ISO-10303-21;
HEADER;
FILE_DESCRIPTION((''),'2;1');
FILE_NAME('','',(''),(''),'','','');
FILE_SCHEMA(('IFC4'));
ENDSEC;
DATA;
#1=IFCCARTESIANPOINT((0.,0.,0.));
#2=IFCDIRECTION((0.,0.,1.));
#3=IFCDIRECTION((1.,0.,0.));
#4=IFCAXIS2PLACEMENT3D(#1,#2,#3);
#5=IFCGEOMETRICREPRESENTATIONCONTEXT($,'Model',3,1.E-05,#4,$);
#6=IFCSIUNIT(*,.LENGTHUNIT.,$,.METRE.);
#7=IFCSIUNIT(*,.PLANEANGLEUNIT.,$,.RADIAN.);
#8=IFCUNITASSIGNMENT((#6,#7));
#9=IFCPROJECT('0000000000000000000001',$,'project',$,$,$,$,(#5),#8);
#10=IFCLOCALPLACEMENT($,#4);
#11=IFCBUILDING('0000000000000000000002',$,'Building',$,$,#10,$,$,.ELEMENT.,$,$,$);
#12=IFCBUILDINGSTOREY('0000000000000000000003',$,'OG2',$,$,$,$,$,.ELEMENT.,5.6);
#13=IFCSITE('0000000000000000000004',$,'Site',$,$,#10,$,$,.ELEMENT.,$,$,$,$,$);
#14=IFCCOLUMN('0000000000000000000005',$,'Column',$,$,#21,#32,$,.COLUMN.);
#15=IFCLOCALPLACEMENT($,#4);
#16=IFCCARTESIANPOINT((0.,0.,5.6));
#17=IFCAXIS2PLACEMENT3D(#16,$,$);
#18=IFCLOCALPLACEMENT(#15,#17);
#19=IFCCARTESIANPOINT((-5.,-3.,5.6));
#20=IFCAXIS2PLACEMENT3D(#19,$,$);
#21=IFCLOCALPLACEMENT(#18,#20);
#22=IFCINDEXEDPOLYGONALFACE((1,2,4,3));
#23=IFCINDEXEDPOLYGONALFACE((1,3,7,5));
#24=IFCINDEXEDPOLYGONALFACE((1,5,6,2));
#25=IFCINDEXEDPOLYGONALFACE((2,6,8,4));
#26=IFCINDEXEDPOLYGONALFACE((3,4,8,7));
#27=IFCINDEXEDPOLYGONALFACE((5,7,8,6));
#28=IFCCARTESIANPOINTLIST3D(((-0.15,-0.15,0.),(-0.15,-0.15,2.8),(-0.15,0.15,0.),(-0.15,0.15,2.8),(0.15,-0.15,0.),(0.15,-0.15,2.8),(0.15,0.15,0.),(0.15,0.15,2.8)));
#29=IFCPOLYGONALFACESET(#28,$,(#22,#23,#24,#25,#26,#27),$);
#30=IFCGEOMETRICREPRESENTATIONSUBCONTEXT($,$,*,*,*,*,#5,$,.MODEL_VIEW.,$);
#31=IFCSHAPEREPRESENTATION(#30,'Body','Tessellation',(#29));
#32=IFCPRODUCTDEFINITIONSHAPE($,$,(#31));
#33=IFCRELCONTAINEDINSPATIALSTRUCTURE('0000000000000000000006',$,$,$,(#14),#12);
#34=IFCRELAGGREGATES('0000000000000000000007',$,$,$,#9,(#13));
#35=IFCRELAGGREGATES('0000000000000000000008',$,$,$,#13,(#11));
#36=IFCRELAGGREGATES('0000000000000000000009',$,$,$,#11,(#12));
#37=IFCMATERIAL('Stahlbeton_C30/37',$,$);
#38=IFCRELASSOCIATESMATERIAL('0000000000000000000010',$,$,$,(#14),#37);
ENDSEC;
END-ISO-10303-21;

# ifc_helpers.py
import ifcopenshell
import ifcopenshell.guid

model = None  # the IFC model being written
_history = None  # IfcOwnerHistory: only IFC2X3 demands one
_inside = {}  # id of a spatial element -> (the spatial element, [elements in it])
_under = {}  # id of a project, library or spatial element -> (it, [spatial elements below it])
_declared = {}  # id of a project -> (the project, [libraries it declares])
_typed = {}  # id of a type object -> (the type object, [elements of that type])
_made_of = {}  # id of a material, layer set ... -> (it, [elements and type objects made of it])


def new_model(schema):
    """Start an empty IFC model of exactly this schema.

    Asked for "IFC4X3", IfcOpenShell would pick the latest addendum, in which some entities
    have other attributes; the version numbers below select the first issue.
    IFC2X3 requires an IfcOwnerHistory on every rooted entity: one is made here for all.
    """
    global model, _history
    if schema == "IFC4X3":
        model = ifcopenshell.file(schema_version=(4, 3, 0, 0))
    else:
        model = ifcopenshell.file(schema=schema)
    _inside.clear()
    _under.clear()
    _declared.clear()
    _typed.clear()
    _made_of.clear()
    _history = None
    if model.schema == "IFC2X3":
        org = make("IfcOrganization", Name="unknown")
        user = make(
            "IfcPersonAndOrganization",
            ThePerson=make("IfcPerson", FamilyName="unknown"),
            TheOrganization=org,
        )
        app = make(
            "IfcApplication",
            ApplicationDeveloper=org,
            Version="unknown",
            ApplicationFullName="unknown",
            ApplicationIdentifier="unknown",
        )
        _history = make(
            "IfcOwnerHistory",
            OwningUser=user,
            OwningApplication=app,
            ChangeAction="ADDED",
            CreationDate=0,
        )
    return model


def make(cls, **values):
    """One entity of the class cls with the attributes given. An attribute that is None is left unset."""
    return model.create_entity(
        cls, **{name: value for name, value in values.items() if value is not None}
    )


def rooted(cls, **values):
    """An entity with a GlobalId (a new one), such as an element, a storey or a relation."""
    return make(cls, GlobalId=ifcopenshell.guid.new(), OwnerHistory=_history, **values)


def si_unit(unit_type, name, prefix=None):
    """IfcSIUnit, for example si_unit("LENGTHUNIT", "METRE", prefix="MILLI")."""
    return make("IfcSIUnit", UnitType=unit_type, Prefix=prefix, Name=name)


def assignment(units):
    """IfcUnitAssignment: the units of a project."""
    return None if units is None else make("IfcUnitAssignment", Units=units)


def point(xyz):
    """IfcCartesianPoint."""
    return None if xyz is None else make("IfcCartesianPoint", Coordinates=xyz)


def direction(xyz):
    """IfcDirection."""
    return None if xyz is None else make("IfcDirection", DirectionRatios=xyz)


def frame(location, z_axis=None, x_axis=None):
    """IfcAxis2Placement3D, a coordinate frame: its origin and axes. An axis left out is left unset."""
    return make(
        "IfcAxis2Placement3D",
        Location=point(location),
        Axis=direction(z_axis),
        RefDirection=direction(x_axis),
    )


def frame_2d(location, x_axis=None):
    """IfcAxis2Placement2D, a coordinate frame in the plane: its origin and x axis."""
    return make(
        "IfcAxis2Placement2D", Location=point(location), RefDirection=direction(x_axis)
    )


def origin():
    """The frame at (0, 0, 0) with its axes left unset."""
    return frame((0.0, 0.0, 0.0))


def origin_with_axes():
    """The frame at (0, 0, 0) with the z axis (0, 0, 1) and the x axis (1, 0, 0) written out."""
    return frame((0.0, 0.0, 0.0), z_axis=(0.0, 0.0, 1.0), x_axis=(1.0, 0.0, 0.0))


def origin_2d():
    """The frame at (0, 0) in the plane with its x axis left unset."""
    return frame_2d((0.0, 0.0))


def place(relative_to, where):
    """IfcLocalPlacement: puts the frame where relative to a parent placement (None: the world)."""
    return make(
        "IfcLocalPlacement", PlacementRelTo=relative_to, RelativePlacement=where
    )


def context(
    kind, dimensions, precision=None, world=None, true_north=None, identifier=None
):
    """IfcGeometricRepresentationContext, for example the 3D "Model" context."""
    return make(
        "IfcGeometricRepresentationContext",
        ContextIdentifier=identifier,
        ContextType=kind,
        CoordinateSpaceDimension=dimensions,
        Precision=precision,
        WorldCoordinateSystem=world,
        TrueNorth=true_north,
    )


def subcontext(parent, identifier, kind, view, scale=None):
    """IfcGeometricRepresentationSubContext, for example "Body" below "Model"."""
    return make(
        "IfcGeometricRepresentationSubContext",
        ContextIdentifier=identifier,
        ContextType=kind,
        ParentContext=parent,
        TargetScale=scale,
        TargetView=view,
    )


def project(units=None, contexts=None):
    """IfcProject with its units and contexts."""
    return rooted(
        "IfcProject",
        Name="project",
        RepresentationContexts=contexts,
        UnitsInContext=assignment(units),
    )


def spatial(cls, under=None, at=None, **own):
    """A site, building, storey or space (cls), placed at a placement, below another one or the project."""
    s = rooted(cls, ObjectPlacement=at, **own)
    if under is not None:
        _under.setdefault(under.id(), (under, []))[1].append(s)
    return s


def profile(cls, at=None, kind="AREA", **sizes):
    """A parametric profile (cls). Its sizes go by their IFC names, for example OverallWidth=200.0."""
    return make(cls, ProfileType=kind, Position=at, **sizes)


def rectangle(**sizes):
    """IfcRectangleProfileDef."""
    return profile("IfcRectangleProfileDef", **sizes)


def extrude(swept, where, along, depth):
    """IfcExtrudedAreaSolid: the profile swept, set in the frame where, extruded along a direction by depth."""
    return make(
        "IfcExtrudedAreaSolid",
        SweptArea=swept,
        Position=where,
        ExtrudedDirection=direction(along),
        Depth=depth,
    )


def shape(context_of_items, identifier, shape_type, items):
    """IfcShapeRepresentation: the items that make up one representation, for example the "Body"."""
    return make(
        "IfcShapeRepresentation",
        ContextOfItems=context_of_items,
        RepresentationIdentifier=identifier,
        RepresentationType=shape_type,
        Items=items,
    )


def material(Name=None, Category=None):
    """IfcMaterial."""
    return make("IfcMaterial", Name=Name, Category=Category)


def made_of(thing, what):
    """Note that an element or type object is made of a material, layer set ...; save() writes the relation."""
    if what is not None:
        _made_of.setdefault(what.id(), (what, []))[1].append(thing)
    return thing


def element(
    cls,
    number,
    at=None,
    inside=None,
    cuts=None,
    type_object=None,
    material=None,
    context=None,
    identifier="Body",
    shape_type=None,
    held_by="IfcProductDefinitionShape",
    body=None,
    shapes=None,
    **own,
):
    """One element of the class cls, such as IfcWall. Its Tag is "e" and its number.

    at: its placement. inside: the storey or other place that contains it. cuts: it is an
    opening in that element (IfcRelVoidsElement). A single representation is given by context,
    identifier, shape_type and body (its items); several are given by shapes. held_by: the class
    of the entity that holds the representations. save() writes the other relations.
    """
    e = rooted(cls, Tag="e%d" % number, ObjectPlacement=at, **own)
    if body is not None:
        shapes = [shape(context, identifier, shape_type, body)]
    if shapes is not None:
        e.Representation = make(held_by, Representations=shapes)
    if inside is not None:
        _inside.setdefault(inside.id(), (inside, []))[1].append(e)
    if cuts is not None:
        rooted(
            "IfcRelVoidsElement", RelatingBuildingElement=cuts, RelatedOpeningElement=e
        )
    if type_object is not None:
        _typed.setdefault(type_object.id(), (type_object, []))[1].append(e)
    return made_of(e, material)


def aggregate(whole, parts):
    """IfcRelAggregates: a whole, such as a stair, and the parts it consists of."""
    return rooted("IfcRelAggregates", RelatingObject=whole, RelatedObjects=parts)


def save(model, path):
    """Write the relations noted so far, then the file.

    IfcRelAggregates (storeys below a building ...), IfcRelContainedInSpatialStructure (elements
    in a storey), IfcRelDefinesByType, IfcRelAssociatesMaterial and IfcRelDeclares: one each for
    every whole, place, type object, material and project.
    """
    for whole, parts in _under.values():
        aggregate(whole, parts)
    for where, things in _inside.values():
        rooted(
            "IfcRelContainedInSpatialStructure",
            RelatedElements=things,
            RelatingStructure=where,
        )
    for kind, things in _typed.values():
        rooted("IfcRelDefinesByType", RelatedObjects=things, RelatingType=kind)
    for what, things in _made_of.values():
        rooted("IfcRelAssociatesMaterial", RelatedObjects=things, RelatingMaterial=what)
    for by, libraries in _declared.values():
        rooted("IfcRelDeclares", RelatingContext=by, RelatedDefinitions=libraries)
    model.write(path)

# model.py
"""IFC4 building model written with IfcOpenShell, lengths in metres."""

from ifc_helpers import new_model, si_unit, frame, origin, origin_with_axes, origin_2d, place, context, subcontext, project, spatial, rectangle, extrude, material, element, save


model = new_model("IFC4")

# Units and contexts
model_context = context("Model", 3, precision=1e-05, world=origin_with_axes())
sub_context = subcontext(model_context, None, None, "MODEL_VIEW")
ifc_project = project(units=[si_unit("LENGTHUNIT", "METRE"), si_unit("PLANEANGLEUNIT", "RADIAN")], contexts=[model_context])

# Site, building, storey
placement_1 = place(None, origin_with_axes())
site = spatial("IfcSite", under=ifc_project, at=placement_1, Name="Site", CompositionType="ELEMENT")
building = spatial("IfcBuilding", under=site, at=placement_1, Name="Building", CompositionType="ELEMENT")
storey = spatial("IfcBuildingStorey", under=building, Name="OG2", CompositionType="ELEMENT", Elevation=5.6)

# Column
ifc_material = material(Name="Stahlbeton_C30/37")
placement_2 = place(None, origin_with_axes())
placement_3 = place(placement_2, frame((0.0, 0.0, 5.6)))
column_placement = place(placement_3, frame((-5.0, -3.0, 5.6)))
element("IfcColumn", 1, at=column_placement, inside=storey, material=ifc_material, Name="Column", PredefinedType="COLUMN", context=sub_context, shape_type="SweptSolid", body=[
    extrude(rectangle(XDim=0.3, YDim=0.3, at=origin_2d()), origin(), (0.0, 0.0, 1.0), 2.8),
])

save(model, "model.ifc")
